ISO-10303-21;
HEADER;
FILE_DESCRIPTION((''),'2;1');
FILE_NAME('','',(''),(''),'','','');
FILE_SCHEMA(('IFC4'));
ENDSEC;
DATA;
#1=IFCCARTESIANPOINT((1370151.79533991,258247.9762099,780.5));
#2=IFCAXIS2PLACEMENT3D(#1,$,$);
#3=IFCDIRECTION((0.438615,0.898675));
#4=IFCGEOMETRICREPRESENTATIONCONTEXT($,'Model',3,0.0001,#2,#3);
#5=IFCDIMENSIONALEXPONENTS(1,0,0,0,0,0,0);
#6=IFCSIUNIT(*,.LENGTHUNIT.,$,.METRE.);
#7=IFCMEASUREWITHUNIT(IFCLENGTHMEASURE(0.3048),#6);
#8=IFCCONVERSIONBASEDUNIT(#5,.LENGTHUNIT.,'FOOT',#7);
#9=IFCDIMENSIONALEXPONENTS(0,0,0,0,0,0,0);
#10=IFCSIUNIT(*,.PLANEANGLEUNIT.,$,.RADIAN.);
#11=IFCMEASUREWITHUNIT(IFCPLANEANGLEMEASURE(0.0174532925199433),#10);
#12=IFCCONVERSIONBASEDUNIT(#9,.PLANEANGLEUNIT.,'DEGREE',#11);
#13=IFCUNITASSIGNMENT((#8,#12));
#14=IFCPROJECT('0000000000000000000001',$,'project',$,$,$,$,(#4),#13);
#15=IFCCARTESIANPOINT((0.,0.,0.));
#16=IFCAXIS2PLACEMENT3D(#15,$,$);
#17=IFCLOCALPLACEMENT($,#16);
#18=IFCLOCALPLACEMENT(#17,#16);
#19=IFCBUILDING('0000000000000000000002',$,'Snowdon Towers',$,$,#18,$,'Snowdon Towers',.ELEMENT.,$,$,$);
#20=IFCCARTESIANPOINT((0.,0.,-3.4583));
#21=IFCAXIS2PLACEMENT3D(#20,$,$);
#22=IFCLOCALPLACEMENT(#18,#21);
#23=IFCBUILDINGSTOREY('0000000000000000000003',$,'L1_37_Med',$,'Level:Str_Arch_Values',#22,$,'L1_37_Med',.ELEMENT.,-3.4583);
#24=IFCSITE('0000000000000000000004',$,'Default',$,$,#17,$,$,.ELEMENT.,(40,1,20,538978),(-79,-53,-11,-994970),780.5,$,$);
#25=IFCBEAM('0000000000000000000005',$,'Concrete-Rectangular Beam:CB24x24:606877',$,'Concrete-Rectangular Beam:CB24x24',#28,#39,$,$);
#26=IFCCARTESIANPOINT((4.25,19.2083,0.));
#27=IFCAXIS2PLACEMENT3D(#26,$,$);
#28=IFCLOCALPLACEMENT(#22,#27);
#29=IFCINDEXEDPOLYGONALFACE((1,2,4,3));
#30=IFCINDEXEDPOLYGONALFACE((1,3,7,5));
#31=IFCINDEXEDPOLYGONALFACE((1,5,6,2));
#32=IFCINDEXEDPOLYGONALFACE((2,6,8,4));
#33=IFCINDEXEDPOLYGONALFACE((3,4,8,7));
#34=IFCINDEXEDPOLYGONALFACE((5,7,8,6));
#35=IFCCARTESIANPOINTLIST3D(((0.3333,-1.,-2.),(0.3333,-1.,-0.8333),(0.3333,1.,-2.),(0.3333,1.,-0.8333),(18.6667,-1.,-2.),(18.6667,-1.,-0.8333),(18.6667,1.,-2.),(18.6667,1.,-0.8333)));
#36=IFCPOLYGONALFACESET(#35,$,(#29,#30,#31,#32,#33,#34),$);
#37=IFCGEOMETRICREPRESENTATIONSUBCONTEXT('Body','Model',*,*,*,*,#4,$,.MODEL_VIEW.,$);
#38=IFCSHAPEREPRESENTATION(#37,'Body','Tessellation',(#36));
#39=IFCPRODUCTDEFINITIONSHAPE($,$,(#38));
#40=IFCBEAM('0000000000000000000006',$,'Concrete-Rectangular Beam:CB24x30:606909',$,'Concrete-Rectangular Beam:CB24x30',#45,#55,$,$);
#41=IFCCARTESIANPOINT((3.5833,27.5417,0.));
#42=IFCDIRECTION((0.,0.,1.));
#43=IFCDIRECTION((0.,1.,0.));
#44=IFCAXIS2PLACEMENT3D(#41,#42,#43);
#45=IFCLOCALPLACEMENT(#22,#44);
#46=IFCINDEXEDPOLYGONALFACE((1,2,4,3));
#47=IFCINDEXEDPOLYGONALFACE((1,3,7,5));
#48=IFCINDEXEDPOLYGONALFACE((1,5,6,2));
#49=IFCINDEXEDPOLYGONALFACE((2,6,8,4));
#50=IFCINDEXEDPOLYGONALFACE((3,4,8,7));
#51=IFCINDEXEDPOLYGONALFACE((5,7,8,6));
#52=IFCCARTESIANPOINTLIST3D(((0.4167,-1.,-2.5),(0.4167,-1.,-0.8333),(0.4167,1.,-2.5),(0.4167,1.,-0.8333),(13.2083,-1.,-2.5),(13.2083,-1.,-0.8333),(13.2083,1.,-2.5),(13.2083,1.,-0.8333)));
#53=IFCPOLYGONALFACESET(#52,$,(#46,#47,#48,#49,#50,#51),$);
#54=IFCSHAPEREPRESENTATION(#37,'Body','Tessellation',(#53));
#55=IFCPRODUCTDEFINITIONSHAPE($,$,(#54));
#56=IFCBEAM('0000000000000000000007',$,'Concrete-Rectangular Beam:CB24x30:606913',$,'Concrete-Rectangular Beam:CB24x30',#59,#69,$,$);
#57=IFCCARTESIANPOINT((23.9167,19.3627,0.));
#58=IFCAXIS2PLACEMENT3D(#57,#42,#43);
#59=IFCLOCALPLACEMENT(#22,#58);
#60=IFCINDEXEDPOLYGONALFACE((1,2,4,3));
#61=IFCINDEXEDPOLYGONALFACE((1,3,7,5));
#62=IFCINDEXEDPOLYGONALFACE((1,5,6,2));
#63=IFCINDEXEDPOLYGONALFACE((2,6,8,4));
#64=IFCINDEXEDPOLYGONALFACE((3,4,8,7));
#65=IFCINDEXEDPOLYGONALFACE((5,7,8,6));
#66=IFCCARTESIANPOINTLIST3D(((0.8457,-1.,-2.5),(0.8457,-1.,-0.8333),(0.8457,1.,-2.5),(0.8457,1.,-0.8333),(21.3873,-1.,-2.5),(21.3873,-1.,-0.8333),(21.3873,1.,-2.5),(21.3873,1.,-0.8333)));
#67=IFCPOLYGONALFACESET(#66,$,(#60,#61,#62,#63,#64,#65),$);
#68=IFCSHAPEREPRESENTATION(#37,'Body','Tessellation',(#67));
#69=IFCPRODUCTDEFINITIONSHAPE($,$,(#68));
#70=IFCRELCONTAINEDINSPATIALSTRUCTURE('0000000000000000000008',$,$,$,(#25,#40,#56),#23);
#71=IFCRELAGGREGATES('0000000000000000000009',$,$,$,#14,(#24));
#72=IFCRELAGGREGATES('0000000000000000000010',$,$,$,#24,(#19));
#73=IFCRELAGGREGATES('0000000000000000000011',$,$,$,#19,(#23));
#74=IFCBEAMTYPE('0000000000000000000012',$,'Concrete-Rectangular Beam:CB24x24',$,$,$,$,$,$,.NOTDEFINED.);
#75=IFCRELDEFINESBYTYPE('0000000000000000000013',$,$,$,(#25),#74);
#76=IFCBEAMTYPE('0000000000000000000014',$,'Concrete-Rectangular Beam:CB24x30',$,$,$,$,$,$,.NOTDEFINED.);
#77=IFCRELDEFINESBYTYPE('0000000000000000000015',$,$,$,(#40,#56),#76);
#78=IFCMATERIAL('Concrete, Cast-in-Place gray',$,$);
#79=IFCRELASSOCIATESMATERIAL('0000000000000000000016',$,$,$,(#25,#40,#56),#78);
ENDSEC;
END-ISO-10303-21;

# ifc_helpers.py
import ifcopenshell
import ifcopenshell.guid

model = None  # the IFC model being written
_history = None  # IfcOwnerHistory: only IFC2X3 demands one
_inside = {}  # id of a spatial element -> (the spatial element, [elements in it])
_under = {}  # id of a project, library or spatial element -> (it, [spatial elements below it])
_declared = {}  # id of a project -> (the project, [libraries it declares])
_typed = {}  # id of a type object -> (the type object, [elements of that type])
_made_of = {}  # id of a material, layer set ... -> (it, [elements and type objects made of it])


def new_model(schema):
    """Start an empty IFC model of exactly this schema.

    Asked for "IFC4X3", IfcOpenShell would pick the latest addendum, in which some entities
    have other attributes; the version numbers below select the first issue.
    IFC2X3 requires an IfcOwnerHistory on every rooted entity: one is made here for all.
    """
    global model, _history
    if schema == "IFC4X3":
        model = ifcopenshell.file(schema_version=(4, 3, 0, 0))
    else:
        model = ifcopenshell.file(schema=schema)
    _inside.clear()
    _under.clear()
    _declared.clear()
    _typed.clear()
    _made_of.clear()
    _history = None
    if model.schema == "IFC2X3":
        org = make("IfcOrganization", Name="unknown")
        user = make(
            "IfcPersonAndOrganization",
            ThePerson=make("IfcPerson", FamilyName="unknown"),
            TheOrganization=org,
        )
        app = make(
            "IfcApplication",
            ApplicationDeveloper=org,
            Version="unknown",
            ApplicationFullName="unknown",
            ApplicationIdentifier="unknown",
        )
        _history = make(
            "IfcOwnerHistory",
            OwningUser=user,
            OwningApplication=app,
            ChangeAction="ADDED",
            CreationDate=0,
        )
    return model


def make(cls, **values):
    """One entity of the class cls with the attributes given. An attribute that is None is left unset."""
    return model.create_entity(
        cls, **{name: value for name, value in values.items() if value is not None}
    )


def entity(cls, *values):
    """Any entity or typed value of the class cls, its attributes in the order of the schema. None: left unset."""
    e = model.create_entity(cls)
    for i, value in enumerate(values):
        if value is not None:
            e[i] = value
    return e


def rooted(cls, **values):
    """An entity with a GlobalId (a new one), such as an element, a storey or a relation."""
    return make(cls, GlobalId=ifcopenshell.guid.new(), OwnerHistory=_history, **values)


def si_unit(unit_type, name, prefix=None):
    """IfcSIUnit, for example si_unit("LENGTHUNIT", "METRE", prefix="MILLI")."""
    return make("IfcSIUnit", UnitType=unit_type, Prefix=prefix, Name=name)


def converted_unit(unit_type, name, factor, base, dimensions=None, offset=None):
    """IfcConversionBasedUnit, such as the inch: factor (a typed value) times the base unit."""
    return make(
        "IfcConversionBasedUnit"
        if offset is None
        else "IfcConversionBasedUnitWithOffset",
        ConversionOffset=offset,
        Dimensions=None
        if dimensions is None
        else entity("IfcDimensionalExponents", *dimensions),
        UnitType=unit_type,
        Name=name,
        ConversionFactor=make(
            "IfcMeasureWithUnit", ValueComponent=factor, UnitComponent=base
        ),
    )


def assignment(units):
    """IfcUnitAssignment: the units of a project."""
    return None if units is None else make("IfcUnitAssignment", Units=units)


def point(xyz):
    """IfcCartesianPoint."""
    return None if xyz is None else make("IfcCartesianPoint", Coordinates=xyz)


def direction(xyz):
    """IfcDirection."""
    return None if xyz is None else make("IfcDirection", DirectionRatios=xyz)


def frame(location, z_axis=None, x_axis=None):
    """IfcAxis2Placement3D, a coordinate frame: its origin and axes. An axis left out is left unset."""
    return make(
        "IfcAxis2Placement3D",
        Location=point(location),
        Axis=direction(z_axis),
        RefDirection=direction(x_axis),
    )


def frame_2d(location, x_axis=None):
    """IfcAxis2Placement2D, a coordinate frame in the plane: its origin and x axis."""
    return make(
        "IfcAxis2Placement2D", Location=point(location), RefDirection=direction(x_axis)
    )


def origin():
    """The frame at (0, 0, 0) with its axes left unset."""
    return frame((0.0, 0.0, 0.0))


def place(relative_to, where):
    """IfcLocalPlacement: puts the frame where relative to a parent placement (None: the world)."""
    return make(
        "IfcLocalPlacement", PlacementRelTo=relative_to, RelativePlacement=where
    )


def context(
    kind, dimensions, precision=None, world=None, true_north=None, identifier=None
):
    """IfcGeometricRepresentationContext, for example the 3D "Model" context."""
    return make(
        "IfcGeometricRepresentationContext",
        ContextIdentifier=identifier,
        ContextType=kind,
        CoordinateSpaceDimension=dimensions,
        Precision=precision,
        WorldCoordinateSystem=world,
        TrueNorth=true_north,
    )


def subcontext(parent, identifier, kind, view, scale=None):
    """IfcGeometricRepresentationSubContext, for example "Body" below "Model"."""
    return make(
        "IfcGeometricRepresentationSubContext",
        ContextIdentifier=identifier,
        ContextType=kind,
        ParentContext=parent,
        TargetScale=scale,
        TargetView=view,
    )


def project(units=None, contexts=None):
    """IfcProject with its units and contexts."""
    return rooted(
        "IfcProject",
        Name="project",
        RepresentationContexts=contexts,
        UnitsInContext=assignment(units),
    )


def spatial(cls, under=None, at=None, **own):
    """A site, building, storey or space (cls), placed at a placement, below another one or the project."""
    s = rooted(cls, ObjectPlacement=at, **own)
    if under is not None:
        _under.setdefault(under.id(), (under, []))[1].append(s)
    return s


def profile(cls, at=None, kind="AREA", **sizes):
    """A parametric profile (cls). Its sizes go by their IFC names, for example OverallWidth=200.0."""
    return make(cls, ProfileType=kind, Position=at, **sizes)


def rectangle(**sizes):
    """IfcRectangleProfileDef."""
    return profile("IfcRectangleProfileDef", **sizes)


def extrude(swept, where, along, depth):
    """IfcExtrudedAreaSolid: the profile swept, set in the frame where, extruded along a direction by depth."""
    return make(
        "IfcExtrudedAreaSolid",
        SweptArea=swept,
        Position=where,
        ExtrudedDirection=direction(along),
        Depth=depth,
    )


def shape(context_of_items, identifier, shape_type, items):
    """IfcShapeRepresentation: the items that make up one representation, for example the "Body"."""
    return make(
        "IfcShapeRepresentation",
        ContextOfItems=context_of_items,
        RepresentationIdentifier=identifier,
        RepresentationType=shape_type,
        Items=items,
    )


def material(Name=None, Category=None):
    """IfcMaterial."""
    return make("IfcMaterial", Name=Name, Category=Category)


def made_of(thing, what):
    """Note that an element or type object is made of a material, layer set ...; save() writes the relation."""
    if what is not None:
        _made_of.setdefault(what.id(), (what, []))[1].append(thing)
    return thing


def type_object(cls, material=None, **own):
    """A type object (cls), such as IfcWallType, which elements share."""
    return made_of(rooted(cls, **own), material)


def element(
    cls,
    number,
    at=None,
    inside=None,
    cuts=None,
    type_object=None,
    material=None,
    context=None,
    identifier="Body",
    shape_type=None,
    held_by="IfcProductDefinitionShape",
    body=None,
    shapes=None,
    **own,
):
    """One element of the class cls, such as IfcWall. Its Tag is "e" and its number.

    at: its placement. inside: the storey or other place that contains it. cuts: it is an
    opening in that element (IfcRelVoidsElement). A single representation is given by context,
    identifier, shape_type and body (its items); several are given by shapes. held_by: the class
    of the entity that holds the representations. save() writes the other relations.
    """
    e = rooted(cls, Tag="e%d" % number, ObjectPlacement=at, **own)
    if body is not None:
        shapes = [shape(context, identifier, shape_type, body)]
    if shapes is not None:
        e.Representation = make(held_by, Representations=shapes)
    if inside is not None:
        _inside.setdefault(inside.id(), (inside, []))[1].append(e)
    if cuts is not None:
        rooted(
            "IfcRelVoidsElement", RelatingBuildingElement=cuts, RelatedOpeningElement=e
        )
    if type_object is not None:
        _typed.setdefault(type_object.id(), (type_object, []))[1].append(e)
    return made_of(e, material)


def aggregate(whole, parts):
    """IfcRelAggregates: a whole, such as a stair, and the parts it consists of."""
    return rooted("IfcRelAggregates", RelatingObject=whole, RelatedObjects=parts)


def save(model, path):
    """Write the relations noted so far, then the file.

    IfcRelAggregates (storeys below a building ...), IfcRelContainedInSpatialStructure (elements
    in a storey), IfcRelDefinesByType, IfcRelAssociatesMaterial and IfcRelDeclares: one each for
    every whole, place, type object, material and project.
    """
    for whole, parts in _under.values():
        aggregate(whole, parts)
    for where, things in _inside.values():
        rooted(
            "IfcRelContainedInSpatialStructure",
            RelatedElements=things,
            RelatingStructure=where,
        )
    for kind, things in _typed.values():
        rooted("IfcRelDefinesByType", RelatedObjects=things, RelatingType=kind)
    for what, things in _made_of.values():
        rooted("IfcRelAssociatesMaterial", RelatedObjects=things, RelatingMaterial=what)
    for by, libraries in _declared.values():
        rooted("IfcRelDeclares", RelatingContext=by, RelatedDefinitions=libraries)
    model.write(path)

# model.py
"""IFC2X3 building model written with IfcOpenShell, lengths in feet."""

from ifc_helpers import new_model, entity, si_unit, converted_unit, direction, frame, frame_2d, origin, place, context, subcontext, project, spatial, rectangle, extrude, material, type_object, element, save


model = new_model("IFC2X3")

# Units and contexts
model_context = context("Model", 3, precision=0.0001, world=frame((1370151.79533991, 258247.9762099, 780.5)), true_north=direction((0.438615, 0.898675)))
body_context = subcontext(model_context, "Body", "Model", "MODEL_VIEW")
ifc_project = project(units=[converted_unit("LENGTHUNIT", "FOOT", entity("IfcLengthMeasure", 0.3048), si_unit("LENGTHUNIT", "METRE"), dimensions=[1, 0, 0, 0, 0, 0, 0]), converted_unit("PLANEANGLEUNIT", "DEGREE", entity("IfcPlaneAngleMeasure", 0.0174532925199433), si_unit("PLANEANGLEUNIT", "RADIAN"), dimensions=[0, 0, 0, 0, 0, 0, 0])], contexts=[model_context])

# Site, building, storey
site_placement = place(None, origin())
site = spatial("IfcSite", under=ifc_project, at=site_placement, Name="Default", CompositionType="ELEMENT", RefLatitude=(40, 1, 20, 538978), RefLongitude=(-79, -53, -11, -994970), RefElevation=780.5)
building_placement = place(site_placement, origin())
building = spatial("IfcBuilding", under=site, at=building_placement, Name="Snowdon Towers", LongName="Snowdon Towers", CompositionType="ELEMENT")
storey_placement = place(building_placement, frame((0.0, 0.0, -3.4583)))
storey = spatial("IfcBuildingStorey", under=building, at=storey_placement, Name="L1_37_Med", ObjectType="Level:Str_Arch_Values", LongName="L1_37_Med", CompositionType="ELEMENT", Elevation=-3.4583)

# Beams
ifc_material_1 = material(Name="Concrete, Cast-in-Place gray")
beam_type_1 = type_object("IfcBeamType", Name="Concrete-Rectangular Beam:CB24x24", PredefinedType="NOTDEFINED")
beam_1_placement = place(storey_placement, frame((4.25, 19.2083, 0.0)))
element("IfcBeam", 1, at=beam_1_placement, inside=storey, type_object=beam_type_1, material=ifc_material_1, Name="Concrete-Rectangular Beam:CB24x24:606877", ObjectType="Concrete-Rectangular Beam:CB24x24", context=body_context, shape_type="SweptSolid", body=[
    extrude(rectangle(XDim=1.1667, YDim=2.0, at=frame_2d((0.0, 0.0), x_axis=(1.0, 0.0))), frame((0.3333, 0.0, -1.4167), z_axis=(1.0, 0.0, 0.0), x_axis=(0.0, 0.0, -1.0)), (0.0, 0.0, 1.0), 18.3333),
])
beam_type_2 = type_object("IfcBeamType", Name="Concrete-Rectangular Beam:CB24x30", PredefinedType="NOTDEFINED")
beam_2_placement = place(storey_placement, frame((3.5833, 27.5417, 0.0), z_axis=(0.0, 0.0, 1.0), x_axis=(0.0, 1.0, 0.0)))
element("IfcBeam", 2, at=beam_2_placement, inside=storey, type_object=beam_type_2, material=ifc_material_1, Name="Concrete-Rectangular Beam:CB24x30:606909", ObjectType="Concrete-Rectangular Beam:CB24x30", context=body_context, shape_type="SweptSolid", body=[
    extrude(rectangle(XDim=1.6667, YDim=2.0, at=frame_2d((0.0, 0.0), x_axis=(1.0, 0.0))), frame((0.4167, 0.0, -1.6667), z_axis=(1.0, 0.0, 0.0), x_axis=(0.0, 0.0, -1.0)), (0.0, 0.0, 1.0), 12.7917),
])
beam_3_placement = place(storey_placement, frame((23.9167, 19.3627, 0.0), z_axis=(0.0, 0.0, 1.0), x_axis=(0.0, 1.0, 0.0)))
element("IfcBeam", 3, at=beam_3_placement, inside=storey, type_object=beam_type_2, material=ifc_material_1, Name="Concrete-Rectangular Beam:CB24x30:606913", ObjectType="Concrete-Rectangular Beam:CB24x30", context=body_context, shape_type="SweptSolid", body=[
    extrude(rectangle(XDim=1.6667, YDim=2.0, at=frame_2d((0.0, 0.0), x_axis=(1.0, 0.0))), frame((0.8457, 0.0, -1.6667), z_axis=(1.0, 0.0, 0.0), x_axis=(0.0, 0.0, -1.0)), (0.0, 0.0, 1.0), 20.5417),
])

save(model, "model.ifc")
